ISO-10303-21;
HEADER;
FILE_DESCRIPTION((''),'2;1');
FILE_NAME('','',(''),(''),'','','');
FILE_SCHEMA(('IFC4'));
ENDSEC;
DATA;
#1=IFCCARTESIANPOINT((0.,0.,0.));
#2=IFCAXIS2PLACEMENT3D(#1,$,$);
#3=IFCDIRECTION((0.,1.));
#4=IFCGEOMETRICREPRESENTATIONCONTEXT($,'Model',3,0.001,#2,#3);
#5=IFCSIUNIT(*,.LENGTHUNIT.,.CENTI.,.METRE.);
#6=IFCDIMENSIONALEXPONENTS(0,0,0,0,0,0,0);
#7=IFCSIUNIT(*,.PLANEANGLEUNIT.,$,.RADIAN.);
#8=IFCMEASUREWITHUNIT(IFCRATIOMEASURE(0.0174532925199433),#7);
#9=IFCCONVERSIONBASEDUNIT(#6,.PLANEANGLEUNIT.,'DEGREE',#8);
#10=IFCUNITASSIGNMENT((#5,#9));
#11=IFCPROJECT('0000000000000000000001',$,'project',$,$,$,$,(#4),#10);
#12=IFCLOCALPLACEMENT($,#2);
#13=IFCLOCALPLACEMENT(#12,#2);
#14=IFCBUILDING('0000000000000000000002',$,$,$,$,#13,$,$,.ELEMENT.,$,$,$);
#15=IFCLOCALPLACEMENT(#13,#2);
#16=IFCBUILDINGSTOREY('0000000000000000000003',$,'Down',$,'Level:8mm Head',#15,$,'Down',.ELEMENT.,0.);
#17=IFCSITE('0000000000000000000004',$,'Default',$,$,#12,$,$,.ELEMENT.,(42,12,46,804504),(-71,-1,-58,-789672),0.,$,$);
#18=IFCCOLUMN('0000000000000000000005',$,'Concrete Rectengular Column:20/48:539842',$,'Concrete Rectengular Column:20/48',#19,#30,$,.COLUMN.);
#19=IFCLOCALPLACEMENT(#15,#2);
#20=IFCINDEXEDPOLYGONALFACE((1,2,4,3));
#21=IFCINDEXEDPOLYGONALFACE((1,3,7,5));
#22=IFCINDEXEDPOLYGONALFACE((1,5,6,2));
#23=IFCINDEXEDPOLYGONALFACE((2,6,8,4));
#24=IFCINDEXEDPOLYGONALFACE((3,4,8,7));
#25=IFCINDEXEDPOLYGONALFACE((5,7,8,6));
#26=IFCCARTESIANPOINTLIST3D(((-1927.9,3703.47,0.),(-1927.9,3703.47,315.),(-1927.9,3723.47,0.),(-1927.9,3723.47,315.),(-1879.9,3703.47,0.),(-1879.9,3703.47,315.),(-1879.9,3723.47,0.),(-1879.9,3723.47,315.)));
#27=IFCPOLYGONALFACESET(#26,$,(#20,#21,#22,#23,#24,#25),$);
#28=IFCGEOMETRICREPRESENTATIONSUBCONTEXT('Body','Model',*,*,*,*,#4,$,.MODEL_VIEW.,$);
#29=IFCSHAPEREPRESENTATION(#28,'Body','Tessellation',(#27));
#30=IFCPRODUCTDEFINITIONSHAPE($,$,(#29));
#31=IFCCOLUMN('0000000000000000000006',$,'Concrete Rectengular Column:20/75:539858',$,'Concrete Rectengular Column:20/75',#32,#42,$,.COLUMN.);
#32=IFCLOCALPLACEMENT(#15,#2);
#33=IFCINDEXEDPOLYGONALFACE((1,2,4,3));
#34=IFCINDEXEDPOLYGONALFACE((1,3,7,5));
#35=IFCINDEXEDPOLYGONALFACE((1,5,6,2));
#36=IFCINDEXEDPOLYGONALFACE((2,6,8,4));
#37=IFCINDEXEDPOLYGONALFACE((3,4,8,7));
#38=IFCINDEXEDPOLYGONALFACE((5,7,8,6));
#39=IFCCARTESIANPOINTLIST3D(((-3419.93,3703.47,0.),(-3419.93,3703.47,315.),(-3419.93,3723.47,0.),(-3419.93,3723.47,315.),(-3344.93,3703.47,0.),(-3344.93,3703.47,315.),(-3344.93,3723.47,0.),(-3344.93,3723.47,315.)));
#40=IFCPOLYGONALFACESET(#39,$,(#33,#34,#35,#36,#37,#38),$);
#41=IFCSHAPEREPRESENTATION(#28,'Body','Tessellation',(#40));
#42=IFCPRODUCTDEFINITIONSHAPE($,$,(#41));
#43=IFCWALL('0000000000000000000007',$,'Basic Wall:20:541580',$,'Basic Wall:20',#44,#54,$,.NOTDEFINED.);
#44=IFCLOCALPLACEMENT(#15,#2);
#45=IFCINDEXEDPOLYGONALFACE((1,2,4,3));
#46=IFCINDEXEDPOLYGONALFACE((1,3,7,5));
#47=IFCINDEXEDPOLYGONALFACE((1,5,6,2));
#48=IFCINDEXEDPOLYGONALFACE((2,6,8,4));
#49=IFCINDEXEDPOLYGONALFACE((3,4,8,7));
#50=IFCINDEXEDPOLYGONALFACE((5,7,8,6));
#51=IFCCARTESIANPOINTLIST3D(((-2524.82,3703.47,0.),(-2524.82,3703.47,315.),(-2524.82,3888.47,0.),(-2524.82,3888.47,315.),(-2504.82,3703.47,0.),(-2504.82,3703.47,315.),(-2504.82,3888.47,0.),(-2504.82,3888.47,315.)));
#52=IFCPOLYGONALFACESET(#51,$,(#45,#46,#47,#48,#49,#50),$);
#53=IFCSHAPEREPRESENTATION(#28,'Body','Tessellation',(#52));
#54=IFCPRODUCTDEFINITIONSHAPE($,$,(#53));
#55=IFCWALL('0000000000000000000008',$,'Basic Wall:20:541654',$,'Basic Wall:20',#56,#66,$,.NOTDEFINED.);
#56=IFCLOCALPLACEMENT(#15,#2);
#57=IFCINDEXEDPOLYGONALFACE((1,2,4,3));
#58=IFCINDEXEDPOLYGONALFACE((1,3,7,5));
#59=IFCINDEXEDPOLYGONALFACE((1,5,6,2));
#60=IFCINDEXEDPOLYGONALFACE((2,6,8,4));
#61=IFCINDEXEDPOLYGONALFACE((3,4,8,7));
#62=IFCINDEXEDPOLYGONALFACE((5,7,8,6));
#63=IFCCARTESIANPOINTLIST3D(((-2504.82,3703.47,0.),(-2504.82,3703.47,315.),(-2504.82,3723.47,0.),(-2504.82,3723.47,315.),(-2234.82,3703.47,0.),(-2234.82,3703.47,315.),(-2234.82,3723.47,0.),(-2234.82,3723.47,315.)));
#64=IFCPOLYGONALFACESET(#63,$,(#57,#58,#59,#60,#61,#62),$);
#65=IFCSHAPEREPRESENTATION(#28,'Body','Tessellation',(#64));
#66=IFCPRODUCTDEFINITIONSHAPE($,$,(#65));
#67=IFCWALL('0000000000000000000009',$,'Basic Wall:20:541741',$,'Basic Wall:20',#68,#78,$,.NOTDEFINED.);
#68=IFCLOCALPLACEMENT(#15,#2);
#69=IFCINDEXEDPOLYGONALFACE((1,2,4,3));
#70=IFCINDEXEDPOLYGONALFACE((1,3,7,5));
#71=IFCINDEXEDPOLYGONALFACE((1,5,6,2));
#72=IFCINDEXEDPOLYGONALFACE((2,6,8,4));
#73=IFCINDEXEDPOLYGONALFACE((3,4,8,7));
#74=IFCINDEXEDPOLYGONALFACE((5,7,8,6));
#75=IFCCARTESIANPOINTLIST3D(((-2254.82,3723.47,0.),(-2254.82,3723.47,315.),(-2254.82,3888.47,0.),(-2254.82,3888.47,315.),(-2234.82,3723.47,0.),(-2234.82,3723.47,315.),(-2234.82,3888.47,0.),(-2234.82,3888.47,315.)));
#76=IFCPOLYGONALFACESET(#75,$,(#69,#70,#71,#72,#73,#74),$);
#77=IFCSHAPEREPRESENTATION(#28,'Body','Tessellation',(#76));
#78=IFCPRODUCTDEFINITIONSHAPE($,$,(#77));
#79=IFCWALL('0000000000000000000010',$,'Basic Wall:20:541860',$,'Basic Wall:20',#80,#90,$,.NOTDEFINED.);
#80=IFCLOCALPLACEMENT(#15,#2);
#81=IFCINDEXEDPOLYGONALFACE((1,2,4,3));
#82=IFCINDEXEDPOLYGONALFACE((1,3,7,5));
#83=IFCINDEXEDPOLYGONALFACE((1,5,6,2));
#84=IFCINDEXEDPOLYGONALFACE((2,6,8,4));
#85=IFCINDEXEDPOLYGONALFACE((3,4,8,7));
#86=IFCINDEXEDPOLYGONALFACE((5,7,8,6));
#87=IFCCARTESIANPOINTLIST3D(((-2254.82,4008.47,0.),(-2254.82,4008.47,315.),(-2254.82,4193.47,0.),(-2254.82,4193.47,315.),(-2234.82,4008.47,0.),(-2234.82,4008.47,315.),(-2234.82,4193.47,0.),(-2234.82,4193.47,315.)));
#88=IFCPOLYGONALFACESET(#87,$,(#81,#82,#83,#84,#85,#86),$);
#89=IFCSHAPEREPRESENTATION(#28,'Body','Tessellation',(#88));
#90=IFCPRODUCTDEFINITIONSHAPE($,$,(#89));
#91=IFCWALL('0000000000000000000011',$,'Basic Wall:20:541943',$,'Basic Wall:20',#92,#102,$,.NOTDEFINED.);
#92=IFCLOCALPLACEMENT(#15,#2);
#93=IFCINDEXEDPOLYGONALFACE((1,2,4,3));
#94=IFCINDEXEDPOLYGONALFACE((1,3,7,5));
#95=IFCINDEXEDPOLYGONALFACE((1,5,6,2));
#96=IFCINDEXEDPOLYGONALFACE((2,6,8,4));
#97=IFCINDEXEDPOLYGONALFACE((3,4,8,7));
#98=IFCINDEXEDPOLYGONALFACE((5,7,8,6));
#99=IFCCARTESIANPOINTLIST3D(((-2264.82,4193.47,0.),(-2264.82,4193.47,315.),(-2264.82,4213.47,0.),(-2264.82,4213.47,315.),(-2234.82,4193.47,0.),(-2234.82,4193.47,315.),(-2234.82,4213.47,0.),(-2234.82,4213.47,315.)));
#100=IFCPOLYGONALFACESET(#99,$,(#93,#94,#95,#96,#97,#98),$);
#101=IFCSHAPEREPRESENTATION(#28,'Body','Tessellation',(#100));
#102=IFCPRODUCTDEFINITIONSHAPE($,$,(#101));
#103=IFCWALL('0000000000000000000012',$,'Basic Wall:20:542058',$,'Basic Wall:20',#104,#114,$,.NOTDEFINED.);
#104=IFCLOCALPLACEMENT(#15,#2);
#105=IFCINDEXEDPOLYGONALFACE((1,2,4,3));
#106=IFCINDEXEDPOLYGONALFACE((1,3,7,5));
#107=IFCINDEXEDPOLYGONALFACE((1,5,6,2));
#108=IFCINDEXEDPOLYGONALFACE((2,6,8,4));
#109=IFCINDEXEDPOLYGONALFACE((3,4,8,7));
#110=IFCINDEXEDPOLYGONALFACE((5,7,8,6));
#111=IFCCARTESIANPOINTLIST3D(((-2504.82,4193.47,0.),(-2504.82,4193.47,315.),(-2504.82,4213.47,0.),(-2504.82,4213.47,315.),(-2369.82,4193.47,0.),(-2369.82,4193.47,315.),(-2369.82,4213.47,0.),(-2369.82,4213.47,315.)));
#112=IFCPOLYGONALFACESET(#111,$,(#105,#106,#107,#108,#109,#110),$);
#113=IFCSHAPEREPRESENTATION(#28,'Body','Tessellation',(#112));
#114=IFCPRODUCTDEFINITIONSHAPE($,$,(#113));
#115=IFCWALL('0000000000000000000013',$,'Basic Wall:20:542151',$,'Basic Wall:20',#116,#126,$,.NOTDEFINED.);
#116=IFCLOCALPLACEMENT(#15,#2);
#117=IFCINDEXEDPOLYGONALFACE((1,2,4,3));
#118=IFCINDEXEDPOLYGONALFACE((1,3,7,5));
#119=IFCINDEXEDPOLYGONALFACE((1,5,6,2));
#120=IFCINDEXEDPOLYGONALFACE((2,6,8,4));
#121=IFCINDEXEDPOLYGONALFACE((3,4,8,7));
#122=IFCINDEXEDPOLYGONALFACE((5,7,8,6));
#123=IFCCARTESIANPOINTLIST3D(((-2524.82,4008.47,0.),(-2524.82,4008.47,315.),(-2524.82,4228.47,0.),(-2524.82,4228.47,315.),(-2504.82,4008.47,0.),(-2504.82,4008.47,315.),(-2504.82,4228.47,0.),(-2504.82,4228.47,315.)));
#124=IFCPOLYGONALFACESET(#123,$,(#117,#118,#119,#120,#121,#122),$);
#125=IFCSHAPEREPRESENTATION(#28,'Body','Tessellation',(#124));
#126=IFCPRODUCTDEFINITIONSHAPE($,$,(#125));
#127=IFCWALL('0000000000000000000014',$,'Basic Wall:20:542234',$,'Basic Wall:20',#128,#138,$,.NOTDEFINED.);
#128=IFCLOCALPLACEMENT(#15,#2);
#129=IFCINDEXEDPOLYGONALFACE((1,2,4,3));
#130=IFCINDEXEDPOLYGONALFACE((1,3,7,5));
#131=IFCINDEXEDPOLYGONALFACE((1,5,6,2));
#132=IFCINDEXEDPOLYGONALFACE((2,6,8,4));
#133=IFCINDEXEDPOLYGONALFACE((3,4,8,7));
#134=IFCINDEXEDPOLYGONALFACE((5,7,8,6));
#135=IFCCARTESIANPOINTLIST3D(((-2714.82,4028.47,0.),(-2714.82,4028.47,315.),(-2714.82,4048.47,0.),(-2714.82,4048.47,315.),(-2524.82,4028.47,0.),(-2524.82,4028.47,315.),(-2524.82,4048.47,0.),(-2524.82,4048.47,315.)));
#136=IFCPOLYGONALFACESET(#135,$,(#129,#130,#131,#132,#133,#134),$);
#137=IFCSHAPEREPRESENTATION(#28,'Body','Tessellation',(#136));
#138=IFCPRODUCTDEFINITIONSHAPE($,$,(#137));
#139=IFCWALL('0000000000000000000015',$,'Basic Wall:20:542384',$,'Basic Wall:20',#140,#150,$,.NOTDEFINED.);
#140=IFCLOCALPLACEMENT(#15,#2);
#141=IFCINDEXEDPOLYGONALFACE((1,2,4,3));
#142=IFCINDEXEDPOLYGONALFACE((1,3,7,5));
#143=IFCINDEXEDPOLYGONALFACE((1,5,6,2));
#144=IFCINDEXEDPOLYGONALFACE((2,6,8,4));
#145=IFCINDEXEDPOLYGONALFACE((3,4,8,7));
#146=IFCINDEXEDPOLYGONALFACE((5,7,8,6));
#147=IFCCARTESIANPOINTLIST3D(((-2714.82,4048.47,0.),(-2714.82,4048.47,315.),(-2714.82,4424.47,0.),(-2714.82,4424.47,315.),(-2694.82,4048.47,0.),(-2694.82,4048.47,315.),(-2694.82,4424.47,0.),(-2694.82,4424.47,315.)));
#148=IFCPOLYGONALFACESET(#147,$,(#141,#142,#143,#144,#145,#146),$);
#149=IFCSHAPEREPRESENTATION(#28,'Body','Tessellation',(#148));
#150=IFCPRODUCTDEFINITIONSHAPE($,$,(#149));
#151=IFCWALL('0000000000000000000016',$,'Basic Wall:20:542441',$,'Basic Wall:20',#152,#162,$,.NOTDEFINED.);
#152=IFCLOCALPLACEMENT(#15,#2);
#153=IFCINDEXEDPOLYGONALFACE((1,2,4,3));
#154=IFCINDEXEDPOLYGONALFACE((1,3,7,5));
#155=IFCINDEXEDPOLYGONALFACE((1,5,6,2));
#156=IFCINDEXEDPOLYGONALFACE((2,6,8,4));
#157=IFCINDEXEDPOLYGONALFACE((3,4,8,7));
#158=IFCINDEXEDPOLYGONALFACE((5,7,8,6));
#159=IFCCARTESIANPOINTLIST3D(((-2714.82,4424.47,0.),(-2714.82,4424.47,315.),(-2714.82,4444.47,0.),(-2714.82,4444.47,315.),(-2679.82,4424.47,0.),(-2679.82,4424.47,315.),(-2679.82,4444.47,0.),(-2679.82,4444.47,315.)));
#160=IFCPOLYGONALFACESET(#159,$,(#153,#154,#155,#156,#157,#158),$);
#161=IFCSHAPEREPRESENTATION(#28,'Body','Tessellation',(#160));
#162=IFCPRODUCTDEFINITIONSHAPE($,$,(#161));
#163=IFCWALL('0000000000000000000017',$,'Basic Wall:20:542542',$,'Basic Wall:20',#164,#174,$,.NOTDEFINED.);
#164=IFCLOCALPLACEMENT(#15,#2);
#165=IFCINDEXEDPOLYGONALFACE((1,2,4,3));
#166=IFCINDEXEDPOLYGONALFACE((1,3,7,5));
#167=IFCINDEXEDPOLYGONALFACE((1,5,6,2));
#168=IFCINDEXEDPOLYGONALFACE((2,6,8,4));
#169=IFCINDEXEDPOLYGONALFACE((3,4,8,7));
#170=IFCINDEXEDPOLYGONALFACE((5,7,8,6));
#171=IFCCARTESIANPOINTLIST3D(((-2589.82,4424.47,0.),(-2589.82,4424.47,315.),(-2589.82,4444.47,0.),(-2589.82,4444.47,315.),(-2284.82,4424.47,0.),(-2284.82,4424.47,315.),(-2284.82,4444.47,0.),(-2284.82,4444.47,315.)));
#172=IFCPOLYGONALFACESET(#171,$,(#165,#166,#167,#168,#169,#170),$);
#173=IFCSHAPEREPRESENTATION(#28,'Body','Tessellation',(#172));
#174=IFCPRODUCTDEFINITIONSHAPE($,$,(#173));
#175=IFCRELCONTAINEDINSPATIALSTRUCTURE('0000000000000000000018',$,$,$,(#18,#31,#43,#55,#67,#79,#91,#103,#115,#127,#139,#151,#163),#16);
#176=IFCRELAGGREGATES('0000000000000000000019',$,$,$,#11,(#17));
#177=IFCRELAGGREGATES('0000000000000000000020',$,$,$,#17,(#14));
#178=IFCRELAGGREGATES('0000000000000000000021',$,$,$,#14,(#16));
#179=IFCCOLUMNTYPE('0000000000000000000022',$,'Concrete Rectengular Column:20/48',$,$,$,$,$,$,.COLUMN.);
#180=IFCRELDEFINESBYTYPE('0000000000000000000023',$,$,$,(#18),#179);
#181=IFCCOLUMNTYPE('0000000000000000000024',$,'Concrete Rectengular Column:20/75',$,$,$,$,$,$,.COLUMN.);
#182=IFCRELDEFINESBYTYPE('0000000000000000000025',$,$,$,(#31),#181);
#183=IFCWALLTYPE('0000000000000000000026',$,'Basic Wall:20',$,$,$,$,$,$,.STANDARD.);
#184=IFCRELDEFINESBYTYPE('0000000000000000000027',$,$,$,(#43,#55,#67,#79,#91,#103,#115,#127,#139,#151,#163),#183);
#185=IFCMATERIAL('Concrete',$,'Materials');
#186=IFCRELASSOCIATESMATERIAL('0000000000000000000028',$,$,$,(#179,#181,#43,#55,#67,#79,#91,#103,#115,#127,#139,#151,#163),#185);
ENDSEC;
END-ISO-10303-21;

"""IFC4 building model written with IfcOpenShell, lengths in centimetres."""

from ifc_helpers import new_model, entity, si_unit, converted_unit, direction, frame, origin, place, context, subcontext, project, spatial, indexed_curve, outline, extrude, source, transform, mapped, material, type_object, type_shapes, element, save


model = new_model("IFC4")

# Units and contexts
model_context = context("Model", 3, precision=0.001, world=origin(), true_north=direction((0.0, 1.0)))
body_context = subcontext(model_context, "Body", "Model", "MODEL_VIEW")
ifc_project = project(units=[si_unit("LENGTHUNIT", "METRE", prefix="CENTI"), converted_unit("PLANEANGLEUNIT", "DEGREE", entity("IfcRatioMeasure", 0.0174532925199433), si_unit("PLANEANGLEUNIT", "RADIAN"), dimensions=[0, 0, 0, 0, 0, 0, 0])], contexts=[model_context])

# Site, building, storey
site_placement = place(None, origin())
site = spatial("IfcSite", under=ifc_project, at=site_placement, Name="Default", CompositionType="ELEMENT", RefLatitude=(42, 12, 46, 804504), RefLongitude=(-71, -1, -58, -789672), RefElevation=0.0)
building_placement = place(site_placement, origin())
building = spatial("IfcBuilding", under=site, at=building_placement, CompositionType="ELEMENT")
storey_placement = place(building_placement, origin())
storey = spatial("IfcBuildingStorey", under=building, at=storey_placement, Name="Down", ObjectType="Level:8mm Head", LongName="Down", CompositionType="ELEMENT", Elevation=0.0)

# Columns
ifc_material = material(Name="Concrete", Category="Materials")
column_type_1 = type_object("IfcColumnType", Name="Concrete Rectengular Column:20/48", PredefinedType="COLUMN", material=ifc_material)
shared_shape_1 = source(origin(), body_context, "Body", "SweptSolid", [
    extrude(outline(indexed_curve([(-10.0, -24.0), (10.0, -24.0), (10.0, 24.0), (-10.0, 24.0), (-10.0, -24.0)], self_intersect=False)), frame((-1903.9, 3713.47, 0.0), z_axis=(0.0, 0.0, 1.0), x_axis=(0.0, -1.0, 0.0)), (0.0, 0.0, 1.0), 315.0),
])
type_shapes(column_type_1, [shared_shape_1])
column_1_placement = place(storey_placement, origin())
element("IfcColumn", 1, at=column_1_placement, inside=storey, type_object=column_type_1, Name="Concrete Rectengular Column:20/48:539842", ObjectType="Concrete Rectengular Column:20/48", PredefinedType="COLUMN", context=body_context, shape_type="MappedRepresentation", body=[
    mapped(shared_shape_1, transform((0.0, 0.0, 0.0), scale=1.0)),
])
column_type_2 = type_object("IfcColumnType", Name="Concrete Rectengular Column:20/75", PredefinedType="COLUMN", material=ifc_material)
shared_shape_2 = source(origin(), body_context, "Body", "SweptSolid", [
    extrude(outline(indexed_curve([(-10.0, -37.5), (10.0, -37.5), (10.0, 37.5), (-10.0, 37.5), (-10.0, -37.5)], self_intersect=False)), frame((-3382.43, 3713.47, 0.0), z_axis=(0.0, 0.0, 1.0), x_axis=(0.0, -1.0, 0.0)), (0.0, 0.0, 1.0), 315.0),
])
type_shapes(column_type_2, [shared_shape_2])
column_2_placement = place(storey_placement, origin())
element("IfcColumn", 2, at=column_2_placement, inside=storey, type_object=column_type_2, Name="Concrete Rectengular Column:20/75:539858", ObjectType="Concrete Rectengular Column:20/75", PredefinedType="COLUMN", context=body_context, shape_type="MappedRepresentation", body=[
    mapped(shared_shape_2, transform((0.0, 0.0, 0.0), scale=1.0)),
])

# Walls
wall_type_1 = type_object("IfcWallType", Name="Basic Wall:20", PredefinedType="STANDARD")
wall_1_placement = place(storey_placement, frame((-2514.82, 3888.47, 0.0), z_axis=(0.0, 0.0, 1.0), x_axis=(0.0, -1.0, 0.0)))
element("IfcWall", 3, at=wall_1_placement, inside=storey, type_object=wall_type_1, material=ifc_material, Name="Basic Wall:20:541580", ObjectType="Basic Wall:20", PredefinedType="NOTDEFINED", context=body_context, shape_type="SweptSolid", body=[
    extrude(outline(indexed_curve([(185.0, 10.0), (0.0, 10.0), (0.0, -10.0), (185.0, -10.0), (185.0, 10.0)], self_intersect=False)), origin(), (0.0, 0.0, 1.0), 315.0),
])
wall_2_placement = place(storey_placement, frame((-2504.82, 3713.47, 0.0)))
element("IfcWall", 4, at=wall_2_placement, inside=storey, type_object=wall_type_1, material=ifc_material, Name="Basic Wall:20:541654", ObjectType="Basic Wall:20", PredefinedType="NOTDEFINED", context=body_context, shape_type="SweptSolid", body=[
    extrude(outline(indexed_curve([(270.0, 10.0), (0.0, 10.0), (0.0, -10.0), (270.0, -10.0), (270.0, 10.0)], self_intersect=False)), origin(), (0.0, 0.0, 1.0), 315.0),
])
wall_3_placement = place(storey_placement, frame((-2244.82, 3723.47, 0.0), z_axis=(0.0, 0.0, 1.0), x_axis=(0.0, 1.0, 0.0)))
element("IfcWall", 5, at=wall_3_placement, inside=storey, type_object=wall_type_1, material=ifc_material, Name="Basic Wall:20:541741", ObjectType="Basic Wall:20", PredefinedType="NOTDEFINED", context=body_context, shape_type="SweptSolid", body=[
    extrude(outline(indexed_curve([(165.0, 10.0), (0.0, 10.0), (0.0, -10.0), (165.0, -10.0), (165.0, 10.0)], self_intersect=False)), origin(), (0.0, 0.0, 1.0), 315.0),
])
wall_4_placement = place(storey_placement, frame((-2244.82, 4008.47, 0.0), z_axis=(0.0, 0.0, 1.0), x_axis=(0.0, 1.0, 0.0)))
element("IfcWall", 6, at=wall_4_placement, inside=storey, type_object=wall_type_1, material=ifc_material, Name="Basic Wall:20:541860", ObjectType="Basic Wall:20", PredefinedType="NOTDEFINED", context=body_context, shape_type="SweptSolid", body=[
    extrude(outline(indexed_curve([(185.0, 10.0), (0.0, 10.0), (0.0, -10.0), (185.0, -10.0), (185.0, 10.0)], self_intersect=False)), origin(), (0.0, 0.0, 1.0), 315.0),
])
wall_5_placement = place(storey_placement, frame((-2234.82, 4203.47, 0.0), z_axis=(0.0, 0.0, 1.0), x_axis=(-1.0, 0.0, 0.0)))
element("IfcWall", 7, at=wall_5_placement, inside=storey, type_object=wall_type_1, material=ifc_material, Name="Basic Wall:20:541943", ObjectType="Basic Wall:20", PredefinedType="NOTDEFINED", context=body_context, shape_type="SweptSolid", body=[
    extrude(outline(indexed_curve([(30.0, 10.0), (0.0, 10.0), (0.0, -10.0), (30.0, -10.0), (30.0, 10.0)], self_intersect=False)), origin(), (0.0, 0.0, 1.0), 315.0),
])
wall_6_placement = place(storey_placement, frame((-2369.82, 4203.47, 0.0), z_axis=(0.0, 0.0, 1.0), x_axis=(-1.0, 0.0, 0.0)))
element("IfcWall", 8, at=wall_6_placement, inside=storey, type_object=wall_type_1, material=ifc_material, Name="Basic Wall:20:542058", ObjectType="Basic Wall:20", PredefinedType="NOTDEFINED", context=body_context, shape_type="SweptSolid", body=[
    extrude(outline(indexed_curve([(135.0, 10.0), (0.0, 10.0), (0.0, -10.0), (135.0, -10.0), (135.0, 10.0)], self_intersect=False)), origin(), (0.0, 0.0, 1.0), 315.0),
])
wall_7_placement = place(storey_placement, frame((-2514.82, 4228.47, 0.0), z_axis=(0.0, 0.0, 1.0), x_axis=(0.0, -1.0, 0.0)))
element("IfcWall", 9, at=wall_7_placement, inside=storey, type_object=wall_type_1, material=ifc_material, Name="Basic Wall:20:542151", ObjectType="Basic Wall:20", PredefinedType="NOTDEFINED", context=body_context, shape_type="SweptSolid", body=[
    extrude(outline(indexed_curve([(220.0, 10.0), (0.0, 10.0), (0.0, -10.0), (220.0, -10.0), (220.0, 10.0)], self_intersect=False)), origin(), (0.0, 0.0, 1.0), 315.0),
])
wall_8_placement = place(storey_placement, frame((-2524.82, 4038.47, 0.0), z_axis=(0.0, 0.0, 1.0), x_axis=(-1.0, 0.0, 0.0)))
element("IfcWall", 10, at=wall_8_placement, inside=storey, type_object=wall_type_1, material=ifc_material, Name="Basic Wall:20:542234", ObjectType="Basic Wall:20", PredefinedType="NOTDEFINED", context=body_context, shape_type="SweptSolid", body=[
    extrude(outline(indexed_curve([(190.0, 10.0), (0.0, 10.0), (0.0, -10.0), (190.0, -10.0), (190.0, 10.0)], self_intersect=False)), origin(), (0.0, 0.0, 1.0), 315.0),
])
wall_9_placement = place(storey_placement, frame((-2704.82, 4048.47, 0.0), z_axis=(0.0, 0.0, 1.0), x_axis=(0.0, 1.0, 0.0)))
element("IfcWall", 11, at=wall_9_placement, inside=storey, type_object=wall_type_1, material=ifc_material, Name="Basic Wall:20:542384", ObjectType="Basic Wall:20", PredefinedType="NOTDEFINED", context=body_context, shape_type="SweptSolid", body=[
    extrude(outline(indexed_curve([(376.0, 10.0), (0.0, 10.0), (0.0, -10.0), (376.0, -10.0), (376.0, 10.0)], self_intersect=False)), origin(), (0.0, 0.0, 1.0), 315.0),
])
wall_10_placement = place(storey_placement, frame((-2714.82, 4434.47, 0.0)))
element("IfcWall", 12, at=wall_10_placement, inside=storey, type_object=wall_type_1, material=ifc_material, Name="Basic Wall:20:542441", ObjectType="Basic Wall:20", PredefinedType="NOTDEFINED", context=body_context, shape_type="SweptSolid", body=[
    extrude(outline(indexed_curve([(35.0, 10.0), (0.0, 10.0), (0.0, -10.0), (35.0, -10.0), (35.0, 10.0)], self_intersect=False)), origin(), (0.0, 0.0, 1.0), 315.0),
])
wall_11_placement = place(storey_placement, frame((-2589.82, 4434.47, 0.0)))
element("IfcWall", 13, at=wall_11_placement, inside=storey, type_object=wall_type_1, material=ifc_material, Name="Basic Wall:20:542542", ObjectType="Basic Wall:20", PredefinedType="NOTDEFINED", context=body_context, shape_type="SweptSolid", body=[
    extrude(outline(indexed_curve([(305.0, 10.0), (0.0, 10.0), (0.0, -10.0), (305.0, -10.0), (305.0, 10.0)], self_intersect=False)), origin(), (0.0, 0.0, 1.0), 315.0),
])

save(model, "model.ifc")
